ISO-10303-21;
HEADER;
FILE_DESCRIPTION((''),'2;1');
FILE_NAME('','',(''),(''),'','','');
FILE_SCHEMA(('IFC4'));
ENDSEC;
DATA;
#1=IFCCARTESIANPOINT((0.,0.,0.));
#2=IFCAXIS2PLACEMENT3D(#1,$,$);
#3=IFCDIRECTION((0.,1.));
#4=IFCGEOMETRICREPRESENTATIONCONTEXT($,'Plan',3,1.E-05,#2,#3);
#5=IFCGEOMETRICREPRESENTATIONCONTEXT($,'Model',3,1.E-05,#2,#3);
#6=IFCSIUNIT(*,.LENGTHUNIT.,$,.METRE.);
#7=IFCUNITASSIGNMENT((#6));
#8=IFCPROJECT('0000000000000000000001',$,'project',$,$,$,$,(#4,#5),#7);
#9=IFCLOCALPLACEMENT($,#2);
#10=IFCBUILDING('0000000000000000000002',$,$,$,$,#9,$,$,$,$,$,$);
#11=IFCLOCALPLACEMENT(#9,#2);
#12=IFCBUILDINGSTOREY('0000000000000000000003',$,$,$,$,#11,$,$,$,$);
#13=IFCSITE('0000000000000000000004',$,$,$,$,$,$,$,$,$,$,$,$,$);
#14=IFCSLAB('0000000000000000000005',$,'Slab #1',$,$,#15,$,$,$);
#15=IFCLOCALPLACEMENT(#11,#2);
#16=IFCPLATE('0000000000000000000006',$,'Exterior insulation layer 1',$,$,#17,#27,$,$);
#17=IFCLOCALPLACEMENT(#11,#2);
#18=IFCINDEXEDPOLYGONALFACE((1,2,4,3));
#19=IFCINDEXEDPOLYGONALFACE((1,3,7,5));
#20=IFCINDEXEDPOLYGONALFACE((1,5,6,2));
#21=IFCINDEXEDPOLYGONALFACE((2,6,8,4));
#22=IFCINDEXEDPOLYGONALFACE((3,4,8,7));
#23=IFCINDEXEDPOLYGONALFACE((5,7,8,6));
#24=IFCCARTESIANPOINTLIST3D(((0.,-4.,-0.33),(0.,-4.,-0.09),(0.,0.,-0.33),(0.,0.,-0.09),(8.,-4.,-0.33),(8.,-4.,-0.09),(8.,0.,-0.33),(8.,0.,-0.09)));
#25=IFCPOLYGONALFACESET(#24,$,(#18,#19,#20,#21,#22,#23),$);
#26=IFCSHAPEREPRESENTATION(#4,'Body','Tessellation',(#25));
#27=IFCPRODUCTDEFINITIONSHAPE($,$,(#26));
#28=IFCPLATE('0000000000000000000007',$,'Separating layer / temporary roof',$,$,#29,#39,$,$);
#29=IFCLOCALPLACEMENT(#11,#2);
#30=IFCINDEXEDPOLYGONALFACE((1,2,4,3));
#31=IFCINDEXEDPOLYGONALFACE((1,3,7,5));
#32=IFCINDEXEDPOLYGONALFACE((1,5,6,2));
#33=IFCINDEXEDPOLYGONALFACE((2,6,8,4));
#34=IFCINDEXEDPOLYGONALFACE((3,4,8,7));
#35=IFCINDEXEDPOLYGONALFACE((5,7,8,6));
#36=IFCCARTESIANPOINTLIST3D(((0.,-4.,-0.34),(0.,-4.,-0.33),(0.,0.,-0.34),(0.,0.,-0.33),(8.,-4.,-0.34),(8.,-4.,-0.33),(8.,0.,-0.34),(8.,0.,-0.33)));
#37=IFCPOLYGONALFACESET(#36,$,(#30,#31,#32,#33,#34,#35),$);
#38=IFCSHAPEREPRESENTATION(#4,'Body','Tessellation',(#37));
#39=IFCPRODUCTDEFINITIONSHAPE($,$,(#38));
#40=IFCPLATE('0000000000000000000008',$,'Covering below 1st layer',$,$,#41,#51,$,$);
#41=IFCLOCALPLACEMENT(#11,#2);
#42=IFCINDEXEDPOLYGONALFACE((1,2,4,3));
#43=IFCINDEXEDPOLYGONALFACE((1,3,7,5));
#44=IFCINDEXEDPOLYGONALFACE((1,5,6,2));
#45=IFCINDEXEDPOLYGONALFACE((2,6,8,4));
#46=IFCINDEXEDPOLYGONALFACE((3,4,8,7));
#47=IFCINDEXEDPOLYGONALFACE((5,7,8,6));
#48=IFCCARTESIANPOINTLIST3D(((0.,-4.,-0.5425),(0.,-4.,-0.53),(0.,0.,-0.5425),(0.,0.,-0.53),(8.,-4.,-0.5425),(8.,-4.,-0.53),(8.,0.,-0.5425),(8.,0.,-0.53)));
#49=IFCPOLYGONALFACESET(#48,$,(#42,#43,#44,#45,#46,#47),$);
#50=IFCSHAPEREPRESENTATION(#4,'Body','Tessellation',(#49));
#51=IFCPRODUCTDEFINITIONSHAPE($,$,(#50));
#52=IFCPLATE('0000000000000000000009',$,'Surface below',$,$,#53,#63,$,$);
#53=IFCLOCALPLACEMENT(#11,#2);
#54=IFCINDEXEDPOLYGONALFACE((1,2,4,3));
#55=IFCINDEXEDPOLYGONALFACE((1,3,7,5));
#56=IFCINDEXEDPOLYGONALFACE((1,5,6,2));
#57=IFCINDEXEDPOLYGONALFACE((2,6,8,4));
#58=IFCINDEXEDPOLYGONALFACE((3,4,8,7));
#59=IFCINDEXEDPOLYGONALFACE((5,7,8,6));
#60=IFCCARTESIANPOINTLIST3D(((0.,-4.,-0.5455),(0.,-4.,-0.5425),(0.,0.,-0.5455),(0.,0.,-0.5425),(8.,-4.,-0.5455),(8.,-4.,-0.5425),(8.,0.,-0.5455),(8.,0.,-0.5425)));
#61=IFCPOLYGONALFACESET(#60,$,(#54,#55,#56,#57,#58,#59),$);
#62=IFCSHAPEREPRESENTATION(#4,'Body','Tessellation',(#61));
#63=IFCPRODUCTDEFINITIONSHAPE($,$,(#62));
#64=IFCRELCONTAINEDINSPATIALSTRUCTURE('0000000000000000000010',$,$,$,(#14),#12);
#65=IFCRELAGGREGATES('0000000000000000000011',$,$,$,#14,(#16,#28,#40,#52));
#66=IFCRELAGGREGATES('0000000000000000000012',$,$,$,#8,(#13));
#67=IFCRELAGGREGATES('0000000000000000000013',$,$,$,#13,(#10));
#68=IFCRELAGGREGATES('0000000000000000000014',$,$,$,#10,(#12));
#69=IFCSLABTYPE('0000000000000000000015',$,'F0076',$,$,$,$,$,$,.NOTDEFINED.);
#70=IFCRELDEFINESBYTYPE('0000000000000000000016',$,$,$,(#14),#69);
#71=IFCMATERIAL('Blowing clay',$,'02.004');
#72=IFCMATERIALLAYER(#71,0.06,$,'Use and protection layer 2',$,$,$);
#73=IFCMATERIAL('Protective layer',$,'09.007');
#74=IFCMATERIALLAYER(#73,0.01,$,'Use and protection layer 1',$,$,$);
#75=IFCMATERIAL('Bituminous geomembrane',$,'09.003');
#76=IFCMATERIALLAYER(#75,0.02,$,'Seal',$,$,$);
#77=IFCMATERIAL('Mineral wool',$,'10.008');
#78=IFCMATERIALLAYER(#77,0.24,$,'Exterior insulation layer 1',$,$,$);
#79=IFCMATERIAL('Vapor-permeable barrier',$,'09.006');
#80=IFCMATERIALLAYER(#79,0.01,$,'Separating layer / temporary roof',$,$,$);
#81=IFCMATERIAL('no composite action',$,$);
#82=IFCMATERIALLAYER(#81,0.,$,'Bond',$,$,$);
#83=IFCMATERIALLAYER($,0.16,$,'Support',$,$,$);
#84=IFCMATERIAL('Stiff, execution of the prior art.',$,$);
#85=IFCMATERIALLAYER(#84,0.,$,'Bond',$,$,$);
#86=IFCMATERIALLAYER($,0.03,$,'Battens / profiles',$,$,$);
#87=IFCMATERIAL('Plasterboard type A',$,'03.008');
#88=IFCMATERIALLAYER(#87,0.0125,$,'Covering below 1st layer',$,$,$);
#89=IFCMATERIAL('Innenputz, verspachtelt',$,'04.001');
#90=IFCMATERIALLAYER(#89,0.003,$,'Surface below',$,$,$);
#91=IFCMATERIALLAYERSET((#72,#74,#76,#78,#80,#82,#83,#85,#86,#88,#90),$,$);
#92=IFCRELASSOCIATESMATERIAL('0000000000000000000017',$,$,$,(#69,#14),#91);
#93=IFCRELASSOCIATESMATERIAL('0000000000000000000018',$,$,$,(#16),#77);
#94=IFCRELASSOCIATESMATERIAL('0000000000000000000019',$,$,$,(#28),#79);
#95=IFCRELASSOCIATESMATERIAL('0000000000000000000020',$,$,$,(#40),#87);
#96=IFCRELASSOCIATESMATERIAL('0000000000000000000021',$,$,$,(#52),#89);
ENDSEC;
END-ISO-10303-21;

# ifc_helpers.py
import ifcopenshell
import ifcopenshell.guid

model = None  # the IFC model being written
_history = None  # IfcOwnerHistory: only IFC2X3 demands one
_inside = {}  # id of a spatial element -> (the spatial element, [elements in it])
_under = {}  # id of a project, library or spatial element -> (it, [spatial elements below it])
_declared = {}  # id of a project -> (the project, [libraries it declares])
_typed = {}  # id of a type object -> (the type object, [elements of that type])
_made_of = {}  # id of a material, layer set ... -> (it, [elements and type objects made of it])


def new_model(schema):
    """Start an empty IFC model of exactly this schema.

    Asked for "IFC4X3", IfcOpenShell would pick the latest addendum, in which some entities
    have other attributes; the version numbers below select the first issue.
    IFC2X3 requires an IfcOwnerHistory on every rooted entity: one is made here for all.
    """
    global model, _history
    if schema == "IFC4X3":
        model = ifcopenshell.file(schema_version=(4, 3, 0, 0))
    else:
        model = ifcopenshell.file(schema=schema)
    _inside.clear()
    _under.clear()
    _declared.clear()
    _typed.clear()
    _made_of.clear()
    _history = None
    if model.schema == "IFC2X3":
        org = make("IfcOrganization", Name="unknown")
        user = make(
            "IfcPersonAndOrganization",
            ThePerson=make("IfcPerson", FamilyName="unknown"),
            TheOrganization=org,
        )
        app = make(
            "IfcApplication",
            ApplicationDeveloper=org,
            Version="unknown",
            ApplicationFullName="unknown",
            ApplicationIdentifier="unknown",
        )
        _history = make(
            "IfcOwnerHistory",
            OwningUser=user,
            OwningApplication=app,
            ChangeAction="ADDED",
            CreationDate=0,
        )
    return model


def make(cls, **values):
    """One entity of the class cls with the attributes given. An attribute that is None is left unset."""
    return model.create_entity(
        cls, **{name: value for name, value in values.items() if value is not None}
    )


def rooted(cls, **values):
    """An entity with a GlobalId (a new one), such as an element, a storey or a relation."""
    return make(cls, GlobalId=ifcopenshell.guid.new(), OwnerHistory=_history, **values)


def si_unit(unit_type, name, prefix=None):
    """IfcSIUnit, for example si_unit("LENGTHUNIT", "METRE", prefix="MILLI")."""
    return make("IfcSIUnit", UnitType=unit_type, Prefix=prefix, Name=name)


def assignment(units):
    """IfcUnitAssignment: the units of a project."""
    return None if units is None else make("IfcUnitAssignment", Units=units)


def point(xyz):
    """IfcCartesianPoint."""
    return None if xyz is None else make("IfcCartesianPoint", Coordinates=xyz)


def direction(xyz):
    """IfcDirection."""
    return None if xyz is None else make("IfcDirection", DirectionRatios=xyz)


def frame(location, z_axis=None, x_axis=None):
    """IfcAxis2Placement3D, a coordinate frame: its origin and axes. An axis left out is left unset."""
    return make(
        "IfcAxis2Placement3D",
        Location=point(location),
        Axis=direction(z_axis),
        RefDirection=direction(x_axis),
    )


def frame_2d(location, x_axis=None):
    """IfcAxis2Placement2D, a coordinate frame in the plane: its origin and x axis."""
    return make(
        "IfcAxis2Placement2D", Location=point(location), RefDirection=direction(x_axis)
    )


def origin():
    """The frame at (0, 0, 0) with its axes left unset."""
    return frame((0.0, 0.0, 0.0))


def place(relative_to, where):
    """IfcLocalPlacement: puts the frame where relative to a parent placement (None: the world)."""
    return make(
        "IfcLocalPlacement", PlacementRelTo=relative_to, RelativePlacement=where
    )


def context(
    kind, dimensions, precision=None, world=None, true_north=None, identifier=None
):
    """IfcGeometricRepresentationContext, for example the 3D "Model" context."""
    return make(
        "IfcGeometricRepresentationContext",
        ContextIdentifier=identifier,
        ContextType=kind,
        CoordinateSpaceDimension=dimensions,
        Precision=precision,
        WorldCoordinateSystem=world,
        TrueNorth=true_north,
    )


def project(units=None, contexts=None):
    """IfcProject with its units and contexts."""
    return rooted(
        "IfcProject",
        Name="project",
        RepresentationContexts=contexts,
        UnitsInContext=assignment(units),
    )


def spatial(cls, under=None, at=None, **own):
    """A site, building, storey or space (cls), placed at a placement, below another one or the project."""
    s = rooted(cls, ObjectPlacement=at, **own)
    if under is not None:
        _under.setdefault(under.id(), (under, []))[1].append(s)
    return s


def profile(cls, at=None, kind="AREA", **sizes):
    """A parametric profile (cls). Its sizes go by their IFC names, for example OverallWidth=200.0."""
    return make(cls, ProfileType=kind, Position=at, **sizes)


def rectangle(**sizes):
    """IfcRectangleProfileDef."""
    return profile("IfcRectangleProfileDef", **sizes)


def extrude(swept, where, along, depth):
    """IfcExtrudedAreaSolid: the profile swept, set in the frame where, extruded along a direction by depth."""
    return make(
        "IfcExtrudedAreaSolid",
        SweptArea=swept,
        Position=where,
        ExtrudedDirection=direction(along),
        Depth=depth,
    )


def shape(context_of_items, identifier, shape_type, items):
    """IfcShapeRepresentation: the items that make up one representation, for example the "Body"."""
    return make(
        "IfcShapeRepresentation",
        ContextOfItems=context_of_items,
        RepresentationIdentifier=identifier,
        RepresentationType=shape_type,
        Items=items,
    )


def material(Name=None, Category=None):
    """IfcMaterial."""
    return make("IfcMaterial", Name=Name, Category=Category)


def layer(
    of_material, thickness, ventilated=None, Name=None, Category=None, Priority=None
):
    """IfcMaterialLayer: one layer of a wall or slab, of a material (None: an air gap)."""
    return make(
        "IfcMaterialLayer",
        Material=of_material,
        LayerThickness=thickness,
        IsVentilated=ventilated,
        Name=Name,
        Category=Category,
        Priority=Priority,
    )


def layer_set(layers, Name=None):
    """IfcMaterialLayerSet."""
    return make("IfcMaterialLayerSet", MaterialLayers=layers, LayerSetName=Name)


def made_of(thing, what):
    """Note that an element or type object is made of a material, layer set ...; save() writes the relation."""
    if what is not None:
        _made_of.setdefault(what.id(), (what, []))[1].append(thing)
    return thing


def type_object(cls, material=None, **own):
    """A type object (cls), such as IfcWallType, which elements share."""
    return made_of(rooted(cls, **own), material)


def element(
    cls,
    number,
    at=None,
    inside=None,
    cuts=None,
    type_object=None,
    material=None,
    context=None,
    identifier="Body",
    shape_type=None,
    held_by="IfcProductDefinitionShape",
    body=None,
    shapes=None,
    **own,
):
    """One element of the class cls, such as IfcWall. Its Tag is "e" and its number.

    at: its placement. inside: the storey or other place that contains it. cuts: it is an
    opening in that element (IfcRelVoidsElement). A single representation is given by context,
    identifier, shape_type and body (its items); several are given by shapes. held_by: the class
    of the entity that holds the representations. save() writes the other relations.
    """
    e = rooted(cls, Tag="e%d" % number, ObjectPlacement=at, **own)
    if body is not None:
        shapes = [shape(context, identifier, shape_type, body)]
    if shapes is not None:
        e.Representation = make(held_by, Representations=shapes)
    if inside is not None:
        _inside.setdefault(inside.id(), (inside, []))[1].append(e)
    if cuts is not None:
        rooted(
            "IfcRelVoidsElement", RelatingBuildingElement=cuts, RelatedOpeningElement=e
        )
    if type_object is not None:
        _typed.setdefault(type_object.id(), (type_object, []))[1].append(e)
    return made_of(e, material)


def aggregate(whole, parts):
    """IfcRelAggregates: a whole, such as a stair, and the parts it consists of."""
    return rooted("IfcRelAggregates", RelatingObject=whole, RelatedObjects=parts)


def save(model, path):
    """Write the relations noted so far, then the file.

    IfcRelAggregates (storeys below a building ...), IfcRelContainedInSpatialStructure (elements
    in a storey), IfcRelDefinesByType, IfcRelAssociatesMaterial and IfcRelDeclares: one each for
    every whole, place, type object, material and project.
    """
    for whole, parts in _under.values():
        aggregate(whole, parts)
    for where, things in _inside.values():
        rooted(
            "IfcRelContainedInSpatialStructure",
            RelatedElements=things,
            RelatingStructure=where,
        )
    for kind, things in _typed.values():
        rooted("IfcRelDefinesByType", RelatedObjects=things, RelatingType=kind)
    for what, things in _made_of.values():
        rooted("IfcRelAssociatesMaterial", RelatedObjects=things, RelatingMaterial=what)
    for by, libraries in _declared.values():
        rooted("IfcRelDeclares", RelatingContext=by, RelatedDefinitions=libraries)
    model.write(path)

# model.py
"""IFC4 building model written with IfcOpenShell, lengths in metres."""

from ifc_helpers import new_model, si_unit, direction, frame, frame_2d, origin, place, context, project, spatial, rectangle, extrude, material, layer, layer_set, type_object, element, aggregate, save


model = new_model("IFC4")

# Units and contexts
plan_context = context("Plan", 3, precision=1e-05, world=origin(), true_north=direction((0.0, 1.0)))
model_context = context("Model", 3, precision=1e-05, world=origin(), true_north=direction((0.0, 1.0)))
ifc_project = project(units=[si_unit("LENGTHUNIT", "METRE")], contexts=[plan_context, model_context])

# Site, building, storey
site = spatial("IfcSite", under=ifc_project)
building_placement = place(None, origin())
building = spatial("IfcBuilding", under=site, at=building_placement)
storey_placement = place(building_placement, origin())
storey = spatial("IfcBuildingStorey", under=building, at=storey_placement)

# Slab, plates
ifc_material_1 = material(Name="Blowing clay", Category="02.004")
ifc_layer_1 = layer(ifc_material_1, 0.06, Name="Use and protection layer 2")
ifc_material_2 = material(Name="Protective layer", Category="09.007")
ifc_layer_2 = layer(ifc_material_2, 0.01, Name="Use and protection layer 1")
ifc_material_3 = material(Name="Bituminous geomembrane", Category="09.003")
ifc_layer_3 = layer(ifc_material_3, 0.02, Name="Seal")
ifc_material_4 = material(Name="Mineral wool", Category="10.008")
ifc_layer_4 = layer(ifc_material_4, 0.24, Name="Exterior insulation layer 1")
ifc_material_5 = material(Name="Vapor-permeable barrier", Category="09.006")
ifc_layer_5 = layer(ifc_material_5, 0.01, Name="Separating layer / temporary roof")
ifc_material_6 = material(Name="no composite action")
ifc_layer_6 = layer(ifc_material_6, 0.0, Name="Bond")
ifc_layer_7 = layer(None, 0.16, Name="Support")
ifc_material_7 = material(Name="Stiff, execution of the prior art.")
ifc_layer_8 = layer(ifc_material_7, 0.0, Name="Bond")
ifc_layer_9 = layer(None, 0.03, Name="Battens / profiles")
ifc_material_8 = material(Name="Plasterboard type A", Category="03.008")
ifc_layer_10 = layer(ifc_material_8, 0.0125, Name="Covering below 1st layer")
ifc_material_9 = material(Name="Innenputz, verspachtelt", Category="04.001")
ifc_layer_11 = layer(ifc_material_9, 0.003, Name="Surface below")
ifc_layer_set = layer_set([ifc_layer_1, ifc_layer_2, ifc_layer_3, ifc_layer_4, ifc_layer_5, ifc_layer_6, ifc_layer_7, ifc_layer_8, ifc_layer_9, ifc_layer_10, ifc_layer_11])
slab_type = type_object("IfcSlabType", Name="F0076", PredefinedType="NOTDEFINED", material=ifc_layer_set)
slab_placement = place(None, frame((0.0, 0.0, 0.0), z_axis=(0.0, 0.0, -1.0), x_axis=(1.0, 0.0, 0.0)))
slab = element("IfcSlab", 1, at=slab_placement, inside=storey, type_object=slab_type, material=ifc_layer_set, Name="Slab #1")
plate_1_placement = place(slab_placement, origin())
plate_1 = element("IfcPlate", 2, at=plate_1_placement, material=ifc_material_4, Name="Exterior insulation layer 1", context=plan_context, shape_type="SweptSolid", body=[
    extrude(rectangle(XDim=8.0, YDim=4.0, at=frame_2d((4.0, 2.0), x_axis=(1.0, 0.0))), frame((0.0, 0.0, 0.09), z_axis=(0.0, 0.0, 1.0), x_axis=(1.0, 0.0, 0.0)), (0.0, 0.0, 1.0), 0.24),
])
plate_2_placement = place(slab_placement, origin())
plate_2 = element("IfcPlate", 3, at=plate_2_placement, material=ifc_material_5, Name="Separating layer / temporary roof", context=plan_context, shape_type="SweptSolid", body=[
    extrude(rectangle(XDim=8.0, YDim=4.0, at=frame_2d((4.0, 2.0), x_axis=(1.0, 0.0))), frame((0.0, 0.0, 0.33), z_axis=(0.0, 0.0, 1.0), x_axis=(1.0, 0.0, 0.0)), (0.0, 0.0, 1.0), 0.01),
])
plate_3_placement = place(slab_placement, origin())
plate_3 = element("IfcPlate", 4, at=plate_3_placement, material=ifc_material_8, Name="Covering below 1st layer", context=plan_context, shape_type="SweptSolid", body=[
    extrude(rectangle(XDim=8.0, YDim=4.0, at=frame_2d((4.0, 2.0), x_axis=(1.0, 0.0))), frame((0.0, 0.0, 0.53), z_axis=(0.0, 0.0, 1.0), x_axis=(1.0, 0.0, 0.0)), (0.0, 0.0, 1.0), 0.0125),
])
plate_4_placement = place(slab_placement, origin())
plate_4 = element("IfcPlate", 5, at=plate_4_placement, material=ifc_material_9, Name="Surface below", context=plan_context, shape_type="SweptSolid", body=[
    extrude(rectangle(XDim=8.0, YDim=4.0, at=frame_2d((4.0, 2.0), x_axis=(1.0, 0.0))), frame((0.0, 0.0, 0.5425), z_axis=(0.0, 0.0, 1.0), x_axis=(1.0, 0.0, 0.0)), (0.0, 0.0, 1.0), 0.003),
])
aggregate(slab, [plate_1, plate_2, plate_3, plate_4])

save(model, "model.ifc")
